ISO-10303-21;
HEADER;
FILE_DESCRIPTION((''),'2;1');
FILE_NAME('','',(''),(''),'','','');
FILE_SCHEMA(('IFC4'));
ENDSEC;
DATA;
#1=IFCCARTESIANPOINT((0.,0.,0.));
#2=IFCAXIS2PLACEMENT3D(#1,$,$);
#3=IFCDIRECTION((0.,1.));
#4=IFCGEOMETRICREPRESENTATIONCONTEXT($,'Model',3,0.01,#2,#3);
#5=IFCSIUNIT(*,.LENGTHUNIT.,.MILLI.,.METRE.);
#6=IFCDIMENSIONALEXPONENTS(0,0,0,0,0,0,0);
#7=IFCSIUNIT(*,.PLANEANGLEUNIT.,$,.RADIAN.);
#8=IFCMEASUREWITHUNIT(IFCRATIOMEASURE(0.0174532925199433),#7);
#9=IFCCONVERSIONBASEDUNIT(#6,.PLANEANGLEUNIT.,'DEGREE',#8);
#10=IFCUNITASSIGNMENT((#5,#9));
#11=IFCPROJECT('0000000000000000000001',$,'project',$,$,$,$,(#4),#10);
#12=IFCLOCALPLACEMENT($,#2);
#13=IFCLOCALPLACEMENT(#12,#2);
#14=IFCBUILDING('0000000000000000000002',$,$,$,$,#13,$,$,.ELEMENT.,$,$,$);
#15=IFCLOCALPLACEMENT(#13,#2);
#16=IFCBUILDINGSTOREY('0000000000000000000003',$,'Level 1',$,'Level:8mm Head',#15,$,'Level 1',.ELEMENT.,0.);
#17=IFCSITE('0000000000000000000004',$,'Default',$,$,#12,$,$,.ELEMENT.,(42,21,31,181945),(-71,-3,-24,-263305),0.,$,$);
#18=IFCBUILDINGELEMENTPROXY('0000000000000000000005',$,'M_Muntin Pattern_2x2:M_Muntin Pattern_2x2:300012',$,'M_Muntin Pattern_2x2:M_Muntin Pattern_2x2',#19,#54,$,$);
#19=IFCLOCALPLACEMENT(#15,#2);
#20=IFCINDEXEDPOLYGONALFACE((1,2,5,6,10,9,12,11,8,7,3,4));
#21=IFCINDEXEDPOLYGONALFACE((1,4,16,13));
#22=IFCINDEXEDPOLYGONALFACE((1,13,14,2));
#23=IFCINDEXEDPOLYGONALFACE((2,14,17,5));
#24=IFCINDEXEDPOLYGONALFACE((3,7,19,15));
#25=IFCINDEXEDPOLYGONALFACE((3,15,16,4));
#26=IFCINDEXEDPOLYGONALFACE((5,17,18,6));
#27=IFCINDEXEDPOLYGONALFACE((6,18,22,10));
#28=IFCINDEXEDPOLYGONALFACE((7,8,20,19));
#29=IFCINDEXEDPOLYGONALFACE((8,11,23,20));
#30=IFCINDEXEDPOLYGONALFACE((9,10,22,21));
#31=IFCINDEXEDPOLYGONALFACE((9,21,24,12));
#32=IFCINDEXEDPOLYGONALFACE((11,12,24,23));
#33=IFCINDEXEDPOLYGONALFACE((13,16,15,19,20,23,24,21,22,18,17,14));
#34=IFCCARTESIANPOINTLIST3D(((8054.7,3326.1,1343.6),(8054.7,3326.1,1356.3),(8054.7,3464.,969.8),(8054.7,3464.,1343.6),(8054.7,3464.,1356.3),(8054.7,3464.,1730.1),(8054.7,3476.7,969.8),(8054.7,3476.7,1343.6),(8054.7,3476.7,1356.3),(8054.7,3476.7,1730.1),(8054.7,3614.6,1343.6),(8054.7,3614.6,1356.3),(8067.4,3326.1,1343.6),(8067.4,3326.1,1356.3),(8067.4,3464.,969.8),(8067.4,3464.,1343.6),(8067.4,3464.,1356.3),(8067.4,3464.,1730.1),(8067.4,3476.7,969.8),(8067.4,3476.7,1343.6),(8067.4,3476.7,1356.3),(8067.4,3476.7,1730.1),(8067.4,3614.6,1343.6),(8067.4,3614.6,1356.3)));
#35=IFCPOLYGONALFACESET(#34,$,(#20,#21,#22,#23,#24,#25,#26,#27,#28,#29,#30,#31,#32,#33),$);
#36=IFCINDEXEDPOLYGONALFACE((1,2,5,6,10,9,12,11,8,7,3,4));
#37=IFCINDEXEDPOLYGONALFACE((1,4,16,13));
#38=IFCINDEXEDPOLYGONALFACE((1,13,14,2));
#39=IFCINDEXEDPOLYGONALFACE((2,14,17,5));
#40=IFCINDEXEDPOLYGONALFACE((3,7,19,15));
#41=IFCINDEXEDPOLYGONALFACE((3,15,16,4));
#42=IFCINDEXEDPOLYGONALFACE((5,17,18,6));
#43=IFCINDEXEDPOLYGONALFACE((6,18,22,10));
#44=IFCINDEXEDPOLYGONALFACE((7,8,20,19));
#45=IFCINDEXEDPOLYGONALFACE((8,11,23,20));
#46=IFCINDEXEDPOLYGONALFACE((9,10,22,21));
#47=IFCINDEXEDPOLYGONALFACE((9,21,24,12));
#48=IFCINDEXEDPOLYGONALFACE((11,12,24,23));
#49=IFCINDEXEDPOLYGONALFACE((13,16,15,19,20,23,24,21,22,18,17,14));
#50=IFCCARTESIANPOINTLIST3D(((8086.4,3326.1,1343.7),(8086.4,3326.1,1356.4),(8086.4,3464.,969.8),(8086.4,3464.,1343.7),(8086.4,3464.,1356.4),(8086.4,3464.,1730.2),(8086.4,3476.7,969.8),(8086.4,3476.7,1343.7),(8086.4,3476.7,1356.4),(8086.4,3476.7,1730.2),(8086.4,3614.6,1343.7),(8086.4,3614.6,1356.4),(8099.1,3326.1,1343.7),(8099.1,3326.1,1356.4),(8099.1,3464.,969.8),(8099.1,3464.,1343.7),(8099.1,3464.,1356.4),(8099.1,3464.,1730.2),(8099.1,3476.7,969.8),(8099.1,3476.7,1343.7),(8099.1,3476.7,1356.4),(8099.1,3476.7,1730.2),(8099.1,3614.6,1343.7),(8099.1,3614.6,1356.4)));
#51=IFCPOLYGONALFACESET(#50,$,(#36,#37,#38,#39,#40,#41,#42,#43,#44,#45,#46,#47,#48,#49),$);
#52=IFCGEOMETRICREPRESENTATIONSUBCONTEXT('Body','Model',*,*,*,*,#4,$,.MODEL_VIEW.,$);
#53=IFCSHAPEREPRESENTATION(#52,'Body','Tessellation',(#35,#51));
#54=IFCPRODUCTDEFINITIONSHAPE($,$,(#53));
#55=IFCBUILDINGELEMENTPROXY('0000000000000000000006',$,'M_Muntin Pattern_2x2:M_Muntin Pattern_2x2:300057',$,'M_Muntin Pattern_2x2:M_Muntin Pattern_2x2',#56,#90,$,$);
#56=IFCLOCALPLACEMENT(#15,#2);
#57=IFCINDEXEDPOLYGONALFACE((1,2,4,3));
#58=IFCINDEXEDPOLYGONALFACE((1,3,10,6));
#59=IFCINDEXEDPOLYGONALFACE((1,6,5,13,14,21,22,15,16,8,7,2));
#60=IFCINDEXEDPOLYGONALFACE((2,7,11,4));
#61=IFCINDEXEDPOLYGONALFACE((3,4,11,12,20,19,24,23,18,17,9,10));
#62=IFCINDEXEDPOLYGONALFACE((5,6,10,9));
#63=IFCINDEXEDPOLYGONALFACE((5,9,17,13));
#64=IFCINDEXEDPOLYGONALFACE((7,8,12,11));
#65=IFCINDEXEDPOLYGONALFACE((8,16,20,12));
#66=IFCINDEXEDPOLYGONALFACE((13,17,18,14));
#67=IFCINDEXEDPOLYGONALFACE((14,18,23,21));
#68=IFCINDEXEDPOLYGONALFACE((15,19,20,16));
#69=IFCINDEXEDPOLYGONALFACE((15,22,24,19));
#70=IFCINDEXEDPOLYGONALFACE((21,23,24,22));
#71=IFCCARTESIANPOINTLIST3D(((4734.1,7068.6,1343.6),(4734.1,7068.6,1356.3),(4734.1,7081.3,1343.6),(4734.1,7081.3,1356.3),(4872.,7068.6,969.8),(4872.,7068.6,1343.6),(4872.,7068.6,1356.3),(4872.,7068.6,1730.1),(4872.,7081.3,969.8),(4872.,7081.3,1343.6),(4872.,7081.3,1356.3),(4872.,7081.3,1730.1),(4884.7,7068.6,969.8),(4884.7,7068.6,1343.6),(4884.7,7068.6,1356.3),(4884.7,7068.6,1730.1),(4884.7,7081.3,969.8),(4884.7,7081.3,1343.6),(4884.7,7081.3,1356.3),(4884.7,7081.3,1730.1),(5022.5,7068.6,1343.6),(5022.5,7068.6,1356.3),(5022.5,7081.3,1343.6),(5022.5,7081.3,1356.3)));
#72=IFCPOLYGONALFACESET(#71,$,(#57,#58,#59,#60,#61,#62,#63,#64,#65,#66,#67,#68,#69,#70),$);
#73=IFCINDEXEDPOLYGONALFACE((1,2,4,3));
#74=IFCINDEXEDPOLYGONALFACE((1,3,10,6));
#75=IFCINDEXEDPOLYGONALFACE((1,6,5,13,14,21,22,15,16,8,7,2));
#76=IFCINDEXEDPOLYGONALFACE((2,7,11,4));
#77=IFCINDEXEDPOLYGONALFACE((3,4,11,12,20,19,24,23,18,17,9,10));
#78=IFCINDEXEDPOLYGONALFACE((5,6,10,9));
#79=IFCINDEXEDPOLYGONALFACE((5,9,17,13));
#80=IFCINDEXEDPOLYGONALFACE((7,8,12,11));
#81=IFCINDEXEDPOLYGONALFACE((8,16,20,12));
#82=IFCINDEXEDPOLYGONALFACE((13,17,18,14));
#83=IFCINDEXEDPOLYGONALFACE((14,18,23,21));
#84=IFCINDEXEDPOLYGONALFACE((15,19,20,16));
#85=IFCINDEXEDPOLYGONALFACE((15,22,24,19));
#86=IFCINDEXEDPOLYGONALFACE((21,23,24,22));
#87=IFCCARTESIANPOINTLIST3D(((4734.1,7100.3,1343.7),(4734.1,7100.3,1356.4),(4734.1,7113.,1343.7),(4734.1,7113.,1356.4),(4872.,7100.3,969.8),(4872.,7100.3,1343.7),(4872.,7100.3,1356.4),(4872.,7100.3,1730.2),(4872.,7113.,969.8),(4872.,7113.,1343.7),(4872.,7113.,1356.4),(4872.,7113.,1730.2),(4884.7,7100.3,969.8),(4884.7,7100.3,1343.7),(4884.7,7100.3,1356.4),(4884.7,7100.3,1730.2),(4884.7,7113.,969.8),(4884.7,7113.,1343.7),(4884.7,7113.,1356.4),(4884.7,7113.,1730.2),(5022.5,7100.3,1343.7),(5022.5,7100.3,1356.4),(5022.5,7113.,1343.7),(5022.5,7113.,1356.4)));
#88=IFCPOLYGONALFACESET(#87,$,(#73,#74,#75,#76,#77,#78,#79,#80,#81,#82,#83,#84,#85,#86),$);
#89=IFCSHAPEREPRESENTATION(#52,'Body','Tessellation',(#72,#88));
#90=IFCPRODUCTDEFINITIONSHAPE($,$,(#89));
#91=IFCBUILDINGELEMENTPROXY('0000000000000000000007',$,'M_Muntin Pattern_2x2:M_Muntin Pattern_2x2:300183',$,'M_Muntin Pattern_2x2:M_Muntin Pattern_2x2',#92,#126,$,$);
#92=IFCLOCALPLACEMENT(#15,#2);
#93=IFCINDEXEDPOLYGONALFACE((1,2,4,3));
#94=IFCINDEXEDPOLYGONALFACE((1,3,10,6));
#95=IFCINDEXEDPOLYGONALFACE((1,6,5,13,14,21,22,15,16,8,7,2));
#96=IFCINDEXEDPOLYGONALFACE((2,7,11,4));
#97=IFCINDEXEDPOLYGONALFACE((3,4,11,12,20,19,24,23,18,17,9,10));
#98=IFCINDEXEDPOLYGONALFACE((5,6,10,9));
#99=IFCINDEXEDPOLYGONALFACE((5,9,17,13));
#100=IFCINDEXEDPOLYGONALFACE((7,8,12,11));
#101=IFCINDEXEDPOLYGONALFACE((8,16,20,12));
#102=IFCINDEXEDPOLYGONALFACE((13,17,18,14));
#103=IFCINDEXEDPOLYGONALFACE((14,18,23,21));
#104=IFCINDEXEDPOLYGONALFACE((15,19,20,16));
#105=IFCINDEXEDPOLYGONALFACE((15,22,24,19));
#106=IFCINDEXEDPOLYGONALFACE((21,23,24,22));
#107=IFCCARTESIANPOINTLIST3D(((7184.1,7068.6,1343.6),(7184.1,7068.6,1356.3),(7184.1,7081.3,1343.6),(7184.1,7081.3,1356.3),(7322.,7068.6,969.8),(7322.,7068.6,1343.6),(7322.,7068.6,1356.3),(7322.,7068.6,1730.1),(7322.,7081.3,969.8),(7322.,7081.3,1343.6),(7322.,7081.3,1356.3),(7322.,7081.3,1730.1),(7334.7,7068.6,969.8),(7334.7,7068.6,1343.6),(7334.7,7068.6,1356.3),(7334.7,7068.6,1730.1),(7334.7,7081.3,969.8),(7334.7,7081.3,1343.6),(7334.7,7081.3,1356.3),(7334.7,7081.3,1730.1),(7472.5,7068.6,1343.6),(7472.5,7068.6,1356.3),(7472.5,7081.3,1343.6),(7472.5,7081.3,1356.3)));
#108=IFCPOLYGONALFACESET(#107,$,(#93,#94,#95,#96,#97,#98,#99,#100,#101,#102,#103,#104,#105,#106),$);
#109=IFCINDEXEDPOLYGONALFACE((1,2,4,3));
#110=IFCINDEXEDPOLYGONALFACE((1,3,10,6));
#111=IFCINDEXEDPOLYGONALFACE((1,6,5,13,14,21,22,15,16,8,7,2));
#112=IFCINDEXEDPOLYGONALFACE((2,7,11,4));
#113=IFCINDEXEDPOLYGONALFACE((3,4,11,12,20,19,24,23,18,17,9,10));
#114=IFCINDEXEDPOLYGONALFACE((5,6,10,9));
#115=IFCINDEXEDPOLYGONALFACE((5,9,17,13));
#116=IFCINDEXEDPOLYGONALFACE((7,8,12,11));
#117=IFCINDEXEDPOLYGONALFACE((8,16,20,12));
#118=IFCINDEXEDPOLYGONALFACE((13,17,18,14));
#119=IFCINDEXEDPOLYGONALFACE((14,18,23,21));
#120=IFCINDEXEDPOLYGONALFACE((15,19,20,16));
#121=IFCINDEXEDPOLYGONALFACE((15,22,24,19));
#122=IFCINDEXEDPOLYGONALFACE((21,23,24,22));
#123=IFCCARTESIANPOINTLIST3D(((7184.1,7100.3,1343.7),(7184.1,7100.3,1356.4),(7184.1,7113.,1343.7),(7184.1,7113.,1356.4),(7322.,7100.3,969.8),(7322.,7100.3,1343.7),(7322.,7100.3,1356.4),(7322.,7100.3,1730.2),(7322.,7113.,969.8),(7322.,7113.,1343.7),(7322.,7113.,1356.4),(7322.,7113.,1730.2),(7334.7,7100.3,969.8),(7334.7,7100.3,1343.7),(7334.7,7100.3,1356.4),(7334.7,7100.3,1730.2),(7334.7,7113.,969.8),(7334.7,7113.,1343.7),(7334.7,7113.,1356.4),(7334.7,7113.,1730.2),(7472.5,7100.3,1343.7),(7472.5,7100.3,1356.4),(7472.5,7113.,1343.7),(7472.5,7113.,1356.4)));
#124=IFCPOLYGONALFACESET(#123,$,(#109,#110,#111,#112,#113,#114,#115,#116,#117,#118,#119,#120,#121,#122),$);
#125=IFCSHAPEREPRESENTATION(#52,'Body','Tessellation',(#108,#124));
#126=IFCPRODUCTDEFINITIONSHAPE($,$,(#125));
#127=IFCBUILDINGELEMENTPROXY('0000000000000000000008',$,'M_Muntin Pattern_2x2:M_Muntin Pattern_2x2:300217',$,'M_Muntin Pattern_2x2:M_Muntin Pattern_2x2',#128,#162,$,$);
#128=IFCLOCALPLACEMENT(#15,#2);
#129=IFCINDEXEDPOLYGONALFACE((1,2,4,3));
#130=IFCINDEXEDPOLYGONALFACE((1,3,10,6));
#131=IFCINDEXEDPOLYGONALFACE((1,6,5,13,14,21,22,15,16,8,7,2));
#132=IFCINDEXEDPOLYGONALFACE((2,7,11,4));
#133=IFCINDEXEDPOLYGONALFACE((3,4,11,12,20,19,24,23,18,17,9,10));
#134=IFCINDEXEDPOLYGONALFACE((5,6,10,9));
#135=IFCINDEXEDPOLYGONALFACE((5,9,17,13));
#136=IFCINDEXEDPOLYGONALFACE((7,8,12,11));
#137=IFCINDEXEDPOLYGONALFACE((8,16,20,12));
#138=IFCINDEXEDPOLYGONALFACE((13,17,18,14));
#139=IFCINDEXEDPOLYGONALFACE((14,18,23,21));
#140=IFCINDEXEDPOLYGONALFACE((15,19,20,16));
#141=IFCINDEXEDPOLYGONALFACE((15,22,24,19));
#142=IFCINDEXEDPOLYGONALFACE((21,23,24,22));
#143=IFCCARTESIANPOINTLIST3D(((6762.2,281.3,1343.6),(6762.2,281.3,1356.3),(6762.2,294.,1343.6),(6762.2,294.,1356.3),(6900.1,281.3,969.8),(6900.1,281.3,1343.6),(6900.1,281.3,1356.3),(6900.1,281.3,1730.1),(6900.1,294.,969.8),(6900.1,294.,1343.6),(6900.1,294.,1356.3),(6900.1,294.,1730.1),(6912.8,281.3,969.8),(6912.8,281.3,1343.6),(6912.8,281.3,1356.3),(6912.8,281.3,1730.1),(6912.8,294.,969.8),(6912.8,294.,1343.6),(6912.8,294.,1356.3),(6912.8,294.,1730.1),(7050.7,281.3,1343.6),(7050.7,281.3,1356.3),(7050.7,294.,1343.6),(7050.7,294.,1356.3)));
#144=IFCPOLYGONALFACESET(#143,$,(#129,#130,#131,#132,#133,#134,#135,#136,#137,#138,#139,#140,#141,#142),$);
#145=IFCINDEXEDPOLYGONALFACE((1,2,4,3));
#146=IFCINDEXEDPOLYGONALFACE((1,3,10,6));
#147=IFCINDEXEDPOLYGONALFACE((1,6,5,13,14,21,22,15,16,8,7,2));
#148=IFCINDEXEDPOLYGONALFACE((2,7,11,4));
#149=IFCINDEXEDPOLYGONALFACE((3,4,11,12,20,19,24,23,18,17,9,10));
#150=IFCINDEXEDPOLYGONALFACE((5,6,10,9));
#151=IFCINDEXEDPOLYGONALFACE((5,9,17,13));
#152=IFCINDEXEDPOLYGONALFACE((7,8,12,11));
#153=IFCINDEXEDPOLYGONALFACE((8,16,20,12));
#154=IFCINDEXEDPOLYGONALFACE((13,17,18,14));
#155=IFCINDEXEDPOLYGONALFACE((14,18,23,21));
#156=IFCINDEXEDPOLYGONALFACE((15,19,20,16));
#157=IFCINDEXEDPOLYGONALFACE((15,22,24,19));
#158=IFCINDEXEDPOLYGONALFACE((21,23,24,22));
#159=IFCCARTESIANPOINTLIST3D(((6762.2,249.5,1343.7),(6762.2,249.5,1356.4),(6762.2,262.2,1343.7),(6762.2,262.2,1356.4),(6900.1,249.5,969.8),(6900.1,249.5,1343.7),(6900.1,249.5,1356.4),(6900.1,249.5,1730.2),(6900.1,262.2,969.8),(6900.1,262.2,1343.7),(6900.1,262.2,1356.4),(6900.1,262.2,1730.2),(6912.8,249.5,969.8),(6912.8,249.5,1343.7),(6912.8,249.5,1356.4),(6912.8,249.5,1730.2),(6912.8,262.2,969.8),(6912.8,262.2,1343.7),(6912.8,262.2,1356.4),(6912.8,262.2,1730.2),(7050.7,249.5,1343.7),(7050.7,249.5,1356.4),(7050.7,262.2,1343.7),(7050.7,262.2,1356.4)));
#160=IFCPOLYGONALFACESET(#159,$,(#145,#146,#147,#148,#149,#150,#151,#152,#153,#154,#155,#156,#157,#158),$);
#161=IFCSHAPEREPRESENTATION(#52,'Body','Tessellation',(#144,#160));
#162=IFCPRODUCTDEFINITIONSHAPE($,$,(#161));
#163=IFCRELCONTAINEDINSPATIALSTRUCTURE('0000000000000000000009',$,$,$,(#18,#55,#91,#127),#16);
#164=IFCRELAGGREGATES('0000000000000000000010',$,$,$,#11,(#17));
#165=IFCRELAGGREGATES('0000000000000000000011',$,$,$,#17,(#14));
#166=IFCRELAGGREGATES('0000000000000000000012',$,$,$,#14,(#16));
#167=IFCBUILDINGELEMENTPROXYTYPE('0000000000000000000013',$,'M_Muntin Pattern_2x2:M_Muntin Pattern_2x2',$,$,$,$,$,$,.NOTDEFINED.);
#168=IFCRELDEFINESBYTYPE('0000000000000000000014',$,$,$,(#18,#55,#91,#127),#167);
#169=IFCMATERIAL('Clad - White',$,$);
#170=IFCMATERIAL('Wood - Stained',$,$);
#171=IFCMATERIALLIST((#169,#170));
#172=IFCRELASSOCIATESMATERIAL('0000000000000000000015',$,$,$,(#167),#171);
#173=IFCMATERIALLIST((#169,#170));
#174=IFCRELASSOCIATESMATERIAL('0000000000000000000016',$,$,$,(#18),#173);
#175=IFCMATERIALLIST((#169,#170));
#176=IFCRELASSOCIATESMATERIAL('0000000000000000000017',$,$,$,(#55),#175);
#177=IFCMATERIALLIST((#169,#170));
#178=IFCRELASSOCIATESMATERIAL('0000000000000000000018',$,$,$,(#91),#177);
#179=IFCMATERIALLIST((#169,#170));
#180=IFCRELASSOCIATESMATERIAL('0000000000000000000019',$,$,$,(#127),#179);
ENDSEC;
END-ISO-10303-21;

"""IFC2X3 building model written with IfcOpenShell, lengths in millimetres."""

from ifc_helpers import new_model, entity, si_unit, converted_unit, direction, frame, origin, place, context, subcontext, project, spatial, polyline, outline, extrude, source, transform, mapped, material, material_list, type_object, type_shapes, element, save


model = new_model("IFC2X3")

# Units and contexts
model_context = context("Model", 3, precision=0.01, world=origin(), true_north=direction((0.0, 1.0)))
body_context = subcontext(model_context, "Body", "Model", "MODEL_VIEW")
ifc_project = project(units=[si_unit("LENGTHUNIT", "METRE", prefix="MILLI"), converted_unit("PLANEANGLEUNIT", "DEGREE", entity("IfcRatioMeasure", 0.0174532925199433), si_unit("PLANEANGLEUNIT", "RADIAN"), dimensions=[0, 0, 0, 0, 0, 0, 0])], contexts=[model_context])

# Site, building, storey
site_placement = place(None, origin())
site = spatial("IfcSite", under=ifc_project, at=site_placement, Name="Default", CompositionType="ELEMENT", RefLatitude=(42, 21, 31, 181945), RefLongitude=(-71, -3, -24, -263305), RefElevation=0.0)
building_placement = place(site_placement, origin())
building = spatial("IfcBuilding", under=site, at=building_placement, CompositionType="ELEMENT")
storey_placement = place(building_placement, origin())
storey = spatial("IfcBuildingStorey", under=building, at=storey_placement, Name="Level 1", ObjectType="Level:8mm Head", LongName="Level 1", CompositionType="ELEMENT", Elevation=0.0)

# Building element proxies
ifc_material_1 = material(Name="Clad - White")
ifc_material_2 = material(Name="Wood - Stained")
ifc_material_list_1 = material_list([ifc_material_1, ifc_material_2])
ifc_material_list_2 = material_list([ifc_material_1, ifc_material_2])
building_element_proxy_type_1 = type_object("IfcBuildingElementProxyType", Name="M_Muntin Pattern_2x2:M_Muntin Pattern_2x2", PredefinedType="NOTDEFINED", material=ifc_material_list_2)
shared_shape_1 = source(origin(), body_context, "Body", "SweptSolid", [
    extrude(outline(polyline([(6.4, -6.4), (380.1, -6.4), (380.1, 6.3), (6.4, 6.3), (6.4, 144.2), (-6.3, 144.2), (-6.3, 6.3), (-380.2, 6.3), (-380.2, -6.4), (-6.3, -6.4), (-6.3, -144.2), (6.4, -144.2), (6.4, -6.4)])), frame((0.0, 9.5, 380.1), z_axis=(0.0, 1.0, 0.0), x_axis=(0.0, 0.0, 1.0)), (0.0, 0.0, 1.0), 12.7),
    extrude(outline(polyline([(6.4, -6.4), (380.2, -6.4), (380.2, 6.3), (6.4, 6.3), (6.4, 144.2), (-6.3, 144.2), (-6.3, 6.3), (-380.2, 6.3), (-380.2, -6.4), (-6.3, -6.4), (-6.3, -144.2), (6.4, -144.2), (6.4, -6.4)])), frame((0.0, -22.2, 380.2), z_axis=(0.0, 1.0, 0.0), x_axis=(0.0, 0.0, 1.0)), (0.0, 0.0, 1.0), 12.7),
])
type_shapes(building_element_proxy_type_1, [shared_shape_1])
proxy_1_placement = place(storey_placement, frame((8076.9, 3470.4, 969.8), z_axis=(0.0, 0.0, 1.0), x_axis=(0.0, 1.0, 0.0)))
element("IfcBuildingElementProxy", 1, at=proxy_1_placement, inside=storey, type_object=building_element_proxy_type_1, material=ifc_material_list_1, Name="M_Muntin Pattern_2x2:M_Muntin Pattern_2x2:300012", ObjectType="M_Muntin Pattern_2x2:M_Muntin Pattern_2x2", context=body_context, shape_type="MappedRepresentation", body=[
    mapped(shared_shape_1, transform((0.0, 0.0, 0.0), scale=1.0)),
])
ifc_material_list_3 = material_list([ifc_material_1, ifc_material_2])
proxy_2_placement = place(storey_placement, frame((4878.3, 7090.8, 969.8), z_axis=(0.0, 0.0, 1.0), x_axis=(-1.0, 0.0, 0.0)))
element("IfcBuildingElementProxy", 2, at=proxy_2_placement, inside=storey, type_object=building_element_proxy_type_1, material=ifc_material_list_3, Name="M_Muntin Pattern_2x2:M_Muntin Pattern_2x2:300057", ObjectType="M_Muntin Pattern_2x2:M_Muntin Pattern_2x2", context=body_context, shape_type="MappedRepresentation", body=[
    mapped(shared_shape_1, transform((0.0, 0.0, 0.0), scale=1.0)),
])
ifc_material_list_4 = material_list([ifc_material_1, ifc_material_2])
proxy_3_placement = place(storey_placement, frame((7328.3, 7090.8, 969.8), z_axis=(0.0, 0.0, 1.0), x_axis=(-1.0, 0.0, 0.0)))
element("IfcBuildingElementProxy", 3, at=proxy_3_placement, inside=storey, type_object=building_element_proxy_type_1, material=ifc_material_list_4, Name="M_Muntin Pattern_2x2:M_Muntin Pattern_2x2:300183", ObjectType="M_Muntin Pattern_2x2:M_Muntin Pattern_2x2", context=body_context, shape_type="MappedRepresentation", body=[
    mapped(shared_shape_1, transform((0.0, 0.0, 0.0), scale=1.0)),
])
ifc_material_list_5 = material_list([ifc_material_1, ifc_material_2])
proxy_4_placement = place(storey_placement, frame((6906.5, 271.8, 969.8)))
element("IfcBuildingElementProxy", 4, at=proxy_4_placement, inside=storey, type_object=building_element_proxy_type_1, material=ifc_material_list_5, Name="M_Muntin Pattern_2x2:M_Muntin Pattern_2x2:300217", ObjectType="M_Muntin Pattern_2x2:M_Muntin Pattern_2x2", context=body_context, shape_type="MappedRepresentation", body=[
    mapped(shared_shape_1, transform((0.0, 0.0, 0.0), scale=1.0)),
])

save(model, "model.ifc")
